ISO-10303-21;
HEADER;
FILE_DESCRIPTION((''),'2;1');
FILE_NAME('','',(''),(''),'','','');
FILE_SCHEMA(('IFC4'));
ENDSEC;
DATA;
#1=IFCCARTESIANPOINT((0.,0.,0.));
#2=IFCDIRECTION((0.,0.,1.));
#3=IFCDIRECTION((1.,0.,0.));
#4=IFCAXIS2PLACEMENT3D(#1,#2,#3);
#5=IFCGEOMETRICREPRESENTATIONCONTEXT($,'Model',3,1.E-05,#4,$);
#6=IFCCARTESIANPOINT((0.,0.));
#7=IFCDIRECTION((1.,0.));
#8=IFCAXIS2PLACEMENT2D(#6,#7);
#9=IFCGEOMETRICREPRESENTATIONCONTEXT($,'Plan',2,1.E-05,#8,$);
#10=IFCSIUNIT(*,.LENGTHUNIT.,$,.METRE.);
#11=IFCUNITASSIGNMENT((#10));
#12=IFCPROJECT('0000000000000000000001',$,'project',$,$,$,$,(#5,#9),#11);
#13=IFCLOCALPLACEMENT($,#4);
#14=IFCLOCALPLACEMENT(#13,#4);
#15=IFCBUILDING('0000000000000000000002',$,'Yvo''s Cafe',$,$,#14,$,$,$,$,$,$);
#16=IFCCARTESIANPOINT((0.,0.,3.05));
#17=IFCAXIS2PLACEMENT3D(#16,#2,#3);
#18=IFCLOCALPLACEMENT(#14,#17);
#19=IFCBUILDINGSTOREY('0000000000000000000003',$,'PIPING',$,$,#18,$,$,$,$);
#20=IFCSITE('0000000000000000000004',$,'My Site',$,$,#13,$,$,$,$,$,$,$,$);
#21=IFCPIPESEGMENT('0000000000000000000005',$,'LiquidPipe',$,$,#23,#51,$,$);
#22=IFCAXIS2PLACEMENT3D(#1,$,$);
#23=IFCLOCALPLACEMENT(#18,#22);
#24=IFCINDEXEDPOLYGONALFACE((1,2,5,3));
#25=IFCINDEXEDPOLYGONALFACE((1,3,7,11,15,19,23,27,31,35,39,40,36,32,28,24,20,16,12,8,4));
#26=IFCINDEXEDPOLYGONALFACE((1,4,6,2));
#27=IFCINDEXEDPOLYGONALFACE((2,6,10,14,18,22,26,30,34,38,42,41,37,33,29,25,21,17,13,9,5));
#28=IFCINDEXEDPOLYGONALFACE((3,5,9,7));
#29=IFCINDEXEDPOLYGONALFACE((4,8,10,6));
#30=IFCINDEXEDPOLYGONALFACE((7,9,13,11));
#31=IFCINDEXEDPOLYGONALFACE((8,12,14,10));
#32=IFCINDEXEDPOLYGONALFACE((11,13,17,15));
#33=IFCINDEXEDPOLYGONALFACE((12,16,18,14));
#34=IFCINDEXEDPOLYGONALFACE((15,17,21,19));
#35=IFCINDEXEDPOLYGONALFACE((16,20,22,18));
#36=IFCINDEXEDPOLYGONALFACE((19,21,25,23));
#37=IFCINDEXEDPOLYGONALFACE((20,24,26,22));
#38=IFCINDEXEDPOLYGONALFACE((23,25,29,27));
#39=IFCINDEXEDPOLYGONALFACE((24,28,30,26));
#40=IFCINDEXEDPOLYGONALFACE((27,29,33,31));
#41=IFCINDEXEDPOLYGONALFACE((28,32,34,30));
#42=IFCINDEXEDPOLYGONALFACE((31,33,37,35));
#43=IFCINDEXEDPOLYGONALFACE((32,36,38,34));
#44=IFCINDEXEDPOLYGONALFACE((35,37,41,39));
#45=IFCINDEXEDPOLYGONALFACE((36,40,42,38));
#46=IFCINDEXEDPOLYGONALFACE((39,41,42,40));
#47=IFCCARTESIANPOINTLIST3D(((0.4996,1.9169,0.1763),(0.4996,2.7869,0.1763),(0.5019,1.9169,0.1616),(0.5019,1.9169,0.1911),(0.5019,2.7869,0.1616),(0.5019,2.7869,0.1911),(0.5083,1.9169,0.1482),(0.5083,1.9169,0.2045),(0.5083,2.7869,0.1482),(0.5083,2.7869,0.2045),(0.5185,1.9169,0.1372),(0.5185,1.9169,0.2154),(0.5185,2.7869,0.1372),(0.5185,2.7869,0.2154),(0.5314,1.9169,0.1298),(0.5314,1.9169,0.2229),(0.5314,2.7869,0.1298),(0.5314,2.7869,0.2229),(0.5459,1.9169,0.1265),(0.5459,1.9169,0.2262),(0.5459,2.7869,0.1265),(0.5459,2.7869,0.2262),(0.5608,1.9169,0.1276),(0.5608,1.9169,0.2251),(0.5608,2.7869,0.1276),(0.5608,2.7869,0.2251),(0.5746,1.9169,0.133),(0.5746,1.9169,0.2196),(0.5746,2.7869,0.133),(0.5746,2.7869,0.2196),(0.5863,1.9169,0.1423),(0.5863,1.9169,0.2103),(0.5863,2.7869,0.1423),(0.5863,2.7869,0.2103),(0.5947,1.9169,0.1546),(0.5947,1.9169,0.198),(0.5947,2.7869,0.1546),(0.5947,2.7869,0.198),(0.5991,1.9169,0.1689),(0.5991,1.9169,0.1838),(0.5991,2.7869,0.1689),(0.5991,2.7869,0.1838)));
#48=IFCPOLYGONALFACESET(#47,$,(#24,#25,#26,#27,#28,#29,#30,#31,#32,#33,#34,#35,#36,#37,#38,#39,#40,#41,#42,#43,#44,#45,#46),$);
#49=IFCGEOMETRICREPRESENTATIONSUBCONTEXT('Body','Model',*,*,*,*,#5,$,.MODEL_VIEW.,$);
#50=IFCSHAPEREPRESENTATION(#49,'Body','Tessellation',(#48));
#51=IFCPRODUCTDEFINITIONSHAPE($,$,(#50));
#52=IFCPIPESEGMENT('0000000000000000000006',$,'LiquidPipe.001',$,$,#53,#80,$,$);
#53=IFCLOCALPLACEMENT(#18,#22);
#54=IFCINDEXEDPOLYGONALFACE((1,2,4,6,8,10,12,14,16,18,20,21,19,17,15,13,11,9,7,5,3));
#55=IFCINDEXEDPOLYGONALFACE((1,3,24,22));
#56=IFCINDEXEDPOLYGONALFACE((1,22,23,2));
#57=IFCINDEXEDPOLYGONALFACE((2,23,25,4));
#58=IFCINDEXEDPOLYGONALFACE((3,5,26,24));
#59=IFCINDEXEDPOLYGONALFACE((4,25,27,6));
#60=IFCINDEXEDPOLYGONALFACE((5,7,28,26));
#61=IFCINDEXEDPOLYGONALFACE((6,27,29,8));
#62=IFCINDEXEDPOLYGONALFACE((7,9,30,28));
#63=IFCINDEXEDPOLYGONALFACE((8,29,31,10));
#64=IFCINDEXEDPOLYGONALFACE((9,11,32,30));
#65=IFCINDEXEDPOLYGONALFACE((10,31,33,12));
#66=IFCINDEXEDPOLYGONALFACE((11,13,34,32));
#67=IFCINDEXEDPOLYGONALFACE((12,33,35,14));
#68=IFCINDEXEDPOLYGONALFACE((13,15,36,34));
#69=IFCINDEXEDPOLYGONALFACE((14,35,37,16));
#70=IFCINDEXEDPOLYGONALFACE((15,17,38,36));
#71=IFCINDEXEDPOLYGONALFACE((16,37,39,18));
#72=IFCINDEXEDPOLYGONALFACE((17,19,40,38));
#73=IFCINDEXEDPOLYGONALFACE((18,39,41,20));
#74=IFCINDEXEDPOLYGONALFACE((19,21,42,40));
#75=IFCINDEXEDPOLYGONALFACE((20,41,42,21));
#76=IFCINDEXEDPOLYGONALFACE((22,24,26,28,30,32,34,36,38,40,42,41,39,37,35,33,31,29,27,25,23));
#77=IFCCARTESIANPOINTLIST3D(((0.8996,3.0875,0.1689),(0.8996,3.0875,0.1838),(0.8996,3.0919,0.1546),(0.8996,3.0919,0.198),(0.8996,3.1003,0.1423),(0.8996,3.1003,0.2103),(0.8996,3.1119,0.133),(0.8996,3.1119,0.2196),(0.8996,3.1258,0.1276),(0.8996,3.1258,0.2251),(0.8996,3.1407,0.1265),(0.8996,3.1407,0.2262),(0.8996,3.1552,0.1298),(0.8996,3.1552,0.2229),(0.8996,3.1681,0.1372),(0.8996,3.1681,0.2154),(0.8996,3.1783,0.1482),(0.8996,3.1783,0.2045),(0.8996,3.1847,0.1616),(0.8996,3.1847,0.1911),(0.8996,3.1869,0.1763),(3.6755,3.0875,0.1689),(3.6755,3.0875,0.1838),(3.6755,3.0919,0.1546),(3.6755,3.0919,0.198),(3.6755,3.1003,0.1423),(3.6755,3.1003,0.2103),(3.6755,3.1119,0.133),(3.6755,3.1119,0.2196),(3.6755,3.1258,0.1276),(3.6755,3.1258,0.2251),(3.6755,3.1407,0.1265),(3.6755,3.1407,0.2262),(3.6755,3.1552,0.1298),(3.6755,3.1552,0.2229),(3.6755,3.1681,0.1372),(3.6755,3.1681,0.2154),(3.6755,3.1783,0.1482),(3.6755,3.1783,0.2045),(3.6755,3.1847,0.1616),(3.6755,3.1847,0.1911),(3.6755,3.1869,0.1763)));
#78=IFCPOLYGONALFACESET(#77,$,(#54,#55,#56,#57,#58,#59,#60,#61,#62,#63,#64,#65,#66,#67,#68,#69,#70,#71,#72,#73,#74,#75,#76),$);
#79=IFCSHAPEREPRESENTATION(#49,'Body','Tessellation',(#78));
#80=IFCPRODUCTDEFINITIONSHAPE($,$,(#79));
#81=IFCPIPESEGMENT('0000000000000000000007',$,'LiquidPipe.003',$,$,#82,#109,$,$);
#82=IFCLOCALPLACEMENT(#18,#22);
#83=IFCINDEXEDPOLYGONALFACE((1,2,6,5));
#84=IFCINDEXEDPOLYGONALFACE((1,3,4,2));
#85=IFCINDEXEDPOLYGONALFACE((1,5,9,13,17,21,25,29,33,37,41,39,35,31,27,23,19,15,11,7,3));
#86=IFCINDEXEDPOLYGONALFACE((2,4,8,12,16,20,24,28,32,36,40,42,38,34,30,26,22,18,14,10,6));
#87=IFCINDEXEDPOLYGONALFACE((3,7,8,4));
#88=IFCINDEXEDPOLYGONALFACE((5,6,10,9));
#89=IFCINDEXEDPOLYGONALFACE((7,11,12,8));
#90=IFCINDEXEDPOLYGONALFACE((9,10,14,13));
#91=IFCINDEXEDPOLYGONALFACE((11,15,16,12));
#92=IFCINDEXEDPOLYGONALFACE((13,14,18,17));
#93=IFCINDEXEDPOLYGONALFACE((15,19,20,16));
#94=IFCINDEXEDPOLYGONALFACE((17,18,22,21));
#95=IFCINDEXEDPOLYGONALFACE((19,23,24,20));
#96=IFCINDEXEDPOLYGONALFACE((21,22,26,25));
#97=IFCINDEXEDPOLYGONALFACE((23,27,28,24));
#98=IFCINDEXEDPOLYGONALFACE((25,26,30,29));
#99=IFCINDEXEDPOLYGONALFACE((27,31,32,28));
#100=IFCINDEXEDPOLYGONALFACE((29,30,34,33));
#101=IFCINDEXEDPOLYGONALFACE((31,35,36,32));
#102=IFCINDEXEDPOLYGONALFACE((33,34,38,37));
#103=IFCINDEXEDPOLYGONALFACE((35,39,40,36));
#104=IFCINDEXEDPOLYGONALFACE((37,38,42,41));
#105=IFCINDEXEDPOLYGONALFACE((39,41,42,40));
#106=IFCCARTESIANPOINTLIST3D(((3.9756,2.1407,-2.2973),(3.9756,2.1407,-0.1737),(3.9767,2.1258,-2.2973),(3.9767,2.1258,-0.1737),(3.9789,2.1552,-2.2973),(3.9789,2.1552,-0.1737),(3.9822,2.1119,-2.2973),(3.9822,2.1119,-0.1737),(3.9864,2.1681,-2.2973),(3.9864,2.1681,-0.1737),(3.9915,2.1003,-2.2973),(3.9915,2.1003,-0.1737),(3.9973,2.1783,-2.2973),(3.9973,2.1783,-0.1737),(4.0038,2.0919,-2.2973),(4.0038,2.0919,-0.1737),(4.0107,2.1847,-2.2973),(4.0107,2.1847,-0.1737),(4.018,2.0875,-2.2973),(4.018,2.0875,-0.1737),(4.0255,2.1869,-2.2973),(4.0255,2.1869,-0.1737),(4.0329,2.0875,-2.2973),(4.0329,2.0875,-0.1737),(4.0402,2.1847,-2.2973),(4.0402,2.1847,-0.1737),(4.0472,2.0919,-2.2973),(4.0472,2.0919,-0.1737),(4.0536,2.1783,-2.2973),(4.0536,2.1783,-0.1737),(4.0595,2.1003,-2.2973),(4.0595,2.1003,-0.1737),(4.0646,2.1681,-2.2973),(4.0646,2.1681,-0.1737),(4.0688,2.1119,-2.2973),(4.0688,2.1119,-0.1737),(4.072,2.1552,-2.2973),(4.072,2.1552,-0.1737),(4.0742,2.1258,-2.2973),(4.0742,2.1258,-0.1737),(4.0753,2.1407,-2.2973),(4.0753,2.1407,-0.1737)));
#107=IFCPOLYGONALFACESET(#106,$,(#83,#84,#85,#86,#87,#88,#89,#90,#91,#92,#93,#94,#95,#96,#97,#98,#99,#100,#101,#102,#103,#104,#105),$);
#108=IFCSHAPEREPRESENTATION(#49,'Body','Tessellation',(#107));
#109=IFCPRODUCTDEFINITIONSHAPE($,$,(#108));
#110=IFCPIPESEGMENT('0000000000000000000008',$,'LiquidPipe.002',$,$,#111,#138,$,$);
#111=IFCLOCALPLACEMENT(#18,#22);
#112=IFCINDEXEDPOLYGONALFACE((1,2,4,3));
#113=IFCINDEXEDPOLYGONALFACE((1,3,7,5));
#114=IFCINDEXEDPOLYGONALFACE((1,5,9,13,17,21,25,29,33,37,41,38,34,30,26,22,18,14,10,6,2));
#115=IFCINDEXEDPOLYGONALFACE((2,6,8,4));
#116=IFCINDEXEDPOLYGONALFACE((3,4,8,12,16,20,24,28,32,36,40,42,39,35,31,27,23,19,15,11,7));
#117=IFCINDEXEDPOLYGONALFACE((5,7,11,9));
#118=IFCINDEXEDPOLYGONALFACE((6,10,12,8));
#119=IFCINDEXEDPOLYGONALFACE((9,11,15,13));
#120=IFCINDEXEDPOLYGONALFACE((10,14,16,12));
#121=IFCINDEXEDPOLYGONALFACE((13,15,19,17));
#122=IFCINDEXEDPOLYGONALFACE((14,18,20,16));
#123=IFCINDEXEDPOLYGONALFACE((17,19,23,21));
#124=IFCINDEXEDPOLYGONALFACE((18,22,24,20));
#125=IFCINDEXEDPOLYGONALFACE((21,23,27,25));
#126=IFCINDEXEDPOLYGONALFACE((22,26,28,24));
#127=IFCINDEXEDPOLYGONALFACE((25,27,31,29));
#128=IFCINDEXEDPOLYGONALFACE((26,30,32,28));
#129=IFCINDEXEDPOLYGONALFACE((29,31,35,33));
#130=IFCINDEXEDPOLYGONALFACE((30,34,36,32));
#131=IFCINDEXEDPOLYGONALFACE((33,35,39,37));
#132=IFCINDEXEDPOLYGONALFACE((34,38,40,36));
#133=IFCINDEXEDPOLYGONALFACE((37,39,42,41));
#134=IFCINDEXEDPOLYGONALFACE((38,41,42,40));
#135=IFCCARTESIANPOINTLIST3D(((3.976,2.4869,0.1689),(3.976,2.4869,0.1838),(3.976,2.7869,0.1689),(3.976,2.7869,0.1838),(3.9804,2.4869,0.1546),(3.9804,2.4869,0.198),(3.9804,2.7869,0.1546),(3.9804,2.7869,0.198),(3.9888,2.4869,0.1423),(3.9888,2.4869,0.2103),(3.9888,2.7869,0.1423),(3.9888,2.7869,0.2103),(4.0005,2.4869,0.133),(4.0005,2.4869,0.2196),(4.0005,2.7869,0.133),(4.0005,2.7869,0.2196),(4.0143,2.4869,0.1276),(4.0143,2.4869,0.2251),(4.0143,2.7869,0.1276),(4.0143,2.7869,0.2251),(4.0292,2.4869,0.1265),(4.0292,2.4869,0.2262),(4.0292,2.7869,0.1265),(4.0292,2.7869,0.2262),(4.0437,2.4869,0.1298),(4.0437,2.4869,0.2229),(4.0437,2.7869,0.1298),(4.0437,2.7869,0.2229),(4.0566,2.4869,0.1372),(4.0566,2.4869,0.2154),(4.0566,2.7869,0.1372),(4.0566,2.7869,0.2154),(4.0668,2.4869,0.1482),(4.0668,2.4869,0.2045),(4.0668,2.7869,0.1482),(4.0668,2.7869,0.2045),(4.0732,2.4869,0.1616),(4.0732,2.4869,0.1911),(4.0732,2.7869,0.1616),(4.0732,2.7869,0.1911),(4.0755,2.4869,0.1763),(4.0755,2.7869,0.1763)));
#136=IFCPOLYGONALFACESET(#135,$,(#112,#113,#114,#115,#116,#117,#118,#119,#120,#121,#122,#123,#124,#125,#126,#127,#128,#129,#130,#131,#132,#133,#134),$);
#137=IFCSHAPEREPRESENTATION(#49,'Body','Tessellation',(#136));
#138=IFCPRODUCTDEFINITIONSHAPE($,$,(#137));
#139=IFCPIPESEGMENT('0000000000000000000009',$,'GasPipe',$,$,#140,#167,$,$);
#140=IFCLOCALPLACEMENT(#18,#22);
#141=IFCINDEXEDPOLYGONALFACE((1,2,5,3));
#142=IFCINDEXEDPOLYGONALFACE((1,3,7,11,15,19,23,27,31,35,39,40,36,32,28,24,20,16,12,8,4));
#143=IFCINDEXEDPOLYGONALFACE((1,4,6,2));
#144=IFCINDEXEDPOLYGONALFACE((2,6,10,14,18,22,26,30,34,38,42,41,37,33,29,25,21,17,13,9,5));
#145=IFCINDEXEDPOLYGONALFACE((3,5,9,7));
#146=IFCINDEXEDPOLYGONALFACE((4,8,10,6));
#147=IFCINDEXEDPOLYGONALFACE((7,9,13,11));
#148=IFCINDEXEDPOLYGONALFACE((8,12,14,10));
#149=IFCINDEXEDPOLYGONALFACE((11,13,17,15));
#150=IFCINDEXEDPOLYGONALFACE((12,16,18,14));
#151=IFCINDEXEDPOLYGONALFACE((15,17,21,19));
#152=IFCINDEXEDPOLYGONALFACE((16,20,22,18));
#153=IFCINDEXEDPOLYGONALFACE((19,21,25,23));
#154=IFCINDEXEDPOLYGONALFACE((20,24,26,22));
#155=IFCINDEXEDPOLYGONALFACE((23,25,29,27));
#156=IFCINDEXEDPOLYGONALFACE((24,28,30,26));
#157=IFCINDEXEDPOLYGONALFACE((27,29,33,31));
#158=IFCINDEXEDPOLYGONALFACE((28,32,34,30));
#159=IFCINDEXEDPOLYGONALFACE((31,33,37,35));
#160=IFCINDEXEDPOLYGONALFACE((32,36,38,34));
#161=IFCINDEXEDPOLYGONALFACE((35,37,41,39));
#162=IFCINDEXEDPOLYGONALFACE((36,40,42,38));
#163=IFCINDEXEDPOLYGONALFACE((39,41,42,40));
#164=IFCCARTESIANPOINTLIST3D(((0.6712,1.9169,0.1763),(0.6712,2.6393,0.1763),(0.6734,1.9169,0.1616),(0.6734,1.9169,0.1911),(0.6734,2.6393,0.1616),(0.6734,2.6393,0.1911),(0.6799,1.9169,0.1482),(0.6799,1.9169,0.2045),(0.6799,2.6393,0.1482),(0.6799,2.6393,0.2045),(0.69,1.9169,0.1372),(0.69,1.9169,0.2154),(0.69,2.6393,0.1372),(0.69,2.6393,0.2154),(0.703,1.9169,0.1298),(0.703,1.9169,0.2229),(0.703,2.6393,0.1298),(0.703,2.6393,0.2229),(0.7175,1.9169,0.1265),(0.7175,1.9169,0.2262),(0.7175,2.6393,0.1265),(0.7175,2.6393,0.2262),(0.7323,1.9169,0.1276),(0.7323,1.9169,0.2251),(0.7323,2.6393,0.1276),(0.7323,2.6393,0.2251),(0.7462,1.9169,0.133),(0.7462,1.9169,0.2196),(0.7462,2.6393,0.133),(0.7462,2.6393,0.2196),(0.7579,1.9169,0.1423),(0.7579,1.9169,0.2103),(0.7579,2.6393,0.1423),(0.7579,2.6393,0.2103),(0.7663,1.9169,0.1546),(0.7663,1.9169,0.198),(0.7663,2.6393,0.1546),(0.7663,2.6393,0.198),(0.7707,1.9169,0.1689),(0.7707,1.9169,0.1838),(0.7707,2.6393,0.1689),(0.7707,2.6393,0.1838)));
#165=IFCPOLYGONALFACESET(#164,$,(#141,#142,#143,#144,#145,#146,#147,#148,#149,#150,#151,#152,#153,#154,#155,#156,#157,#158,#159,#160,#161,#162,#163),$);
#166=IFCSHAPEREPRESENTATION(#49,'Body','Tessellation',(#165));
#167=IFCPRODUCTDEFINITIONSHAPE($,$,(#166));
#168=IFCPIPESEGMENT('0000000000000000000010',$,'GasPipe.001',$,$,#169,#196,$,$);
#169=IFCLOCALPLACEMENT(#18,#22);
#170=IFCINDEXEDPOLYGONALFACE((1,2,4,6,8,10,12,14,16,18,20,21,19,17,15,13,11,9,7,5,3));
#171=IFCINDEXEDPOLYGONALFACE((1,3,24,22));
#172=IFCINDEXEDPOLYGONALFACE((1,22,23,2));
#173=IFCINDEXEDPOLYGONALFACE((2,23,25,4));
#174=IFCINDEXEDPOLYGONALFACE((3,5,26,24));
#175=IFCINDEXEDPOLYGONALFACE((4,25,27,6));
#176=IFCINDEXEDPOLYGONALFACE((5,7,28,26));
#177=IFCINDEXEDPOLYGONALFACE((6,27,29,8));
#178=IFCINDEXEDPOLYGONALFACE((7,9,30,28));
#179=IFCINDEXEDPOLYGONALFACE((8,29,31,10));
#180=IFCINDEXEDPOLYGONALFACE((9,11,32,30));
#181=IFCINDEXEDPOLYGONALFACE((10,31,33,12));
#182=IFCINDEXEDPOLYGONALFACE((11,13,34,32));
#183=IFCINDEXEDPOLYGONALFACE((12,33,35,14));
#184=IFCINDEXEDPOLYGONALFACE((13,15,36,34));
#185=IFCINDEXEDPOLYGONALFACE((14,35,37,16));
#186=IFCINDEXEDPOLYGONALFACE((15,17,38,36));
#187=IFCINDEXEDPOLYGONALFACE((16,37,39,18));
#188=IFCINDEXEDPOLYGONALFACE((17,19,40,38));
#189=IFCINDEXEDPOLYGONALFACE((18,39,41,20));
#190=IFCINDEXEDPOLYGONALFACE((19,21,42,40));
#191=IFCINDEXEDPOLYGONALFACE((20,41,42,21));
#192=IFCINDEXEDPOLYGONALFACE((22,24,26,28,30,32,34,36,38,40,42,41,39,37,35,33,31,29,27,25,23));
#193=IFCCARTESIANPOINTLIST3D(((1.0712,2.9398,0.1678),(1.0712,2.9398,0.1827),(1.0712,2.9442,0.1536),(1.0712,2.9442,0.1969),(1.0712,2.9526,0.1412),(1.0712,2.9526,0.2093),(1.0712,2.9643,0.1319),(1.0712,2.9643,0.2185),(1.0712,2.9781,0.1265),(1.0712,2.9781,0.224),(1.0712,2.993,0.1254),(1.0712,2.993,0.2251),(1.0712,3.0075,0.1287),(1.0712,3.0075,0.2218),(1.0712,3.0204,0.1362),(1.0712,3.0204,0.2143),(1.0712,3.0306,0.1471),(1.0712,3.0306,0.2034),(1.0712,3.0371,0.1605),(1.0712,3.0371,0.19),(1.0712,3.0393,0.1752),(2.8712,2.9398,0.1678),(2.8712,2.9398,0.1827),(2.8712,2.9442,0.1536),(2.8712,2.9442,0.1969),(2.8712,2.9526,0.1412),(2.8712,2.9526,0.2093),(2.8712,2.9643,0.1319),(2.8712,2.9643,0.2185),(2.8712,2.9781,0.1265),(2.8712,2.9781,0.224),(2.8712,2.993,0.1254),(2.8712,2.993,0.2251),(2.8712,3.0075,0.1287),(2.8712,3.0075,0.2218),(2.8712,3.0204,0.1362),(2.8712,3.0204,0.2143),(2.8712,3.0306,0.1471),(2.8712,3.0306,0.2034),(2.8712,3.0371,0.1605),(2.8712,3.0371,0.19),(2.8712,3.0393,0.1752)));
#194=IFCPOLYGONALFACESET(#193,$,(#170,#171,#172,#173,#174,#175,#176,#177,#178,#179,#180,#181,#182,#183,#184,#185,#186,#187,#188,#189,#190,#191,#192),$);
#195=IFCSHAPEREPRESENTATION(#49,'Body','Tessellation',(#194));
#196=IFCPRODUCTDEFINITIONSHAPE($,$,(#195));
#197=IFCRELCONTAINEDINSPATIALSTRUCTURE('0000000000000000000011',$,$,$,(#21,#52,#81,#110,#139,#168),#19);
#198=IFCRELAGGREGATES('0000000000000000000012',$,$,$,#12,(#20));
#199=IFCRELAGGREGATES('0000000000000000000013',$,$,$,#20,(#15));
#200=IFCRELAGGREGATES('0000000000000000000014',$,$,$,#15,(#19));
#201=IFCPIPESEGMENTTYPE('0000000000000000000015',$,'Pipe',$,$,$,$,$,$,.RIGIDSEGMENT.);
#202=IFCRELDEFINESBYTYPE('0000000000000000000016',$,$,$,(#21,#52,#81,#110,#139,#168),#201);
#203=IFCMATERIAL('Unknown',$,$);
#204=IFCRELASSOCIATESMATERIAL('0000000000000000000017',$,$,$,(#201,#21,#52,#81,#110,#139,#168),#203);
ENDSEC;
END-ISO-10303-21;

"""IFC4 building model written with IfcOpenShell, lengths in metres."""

from ifc_helpers import new_model, si_unit, frame, origin_with_axes, origin_2d_with_axis, place, context, subcontext, project, spatial, circle, extrude, material, material_profile, profile_set, profile_usage, type_object, element, save


model = new_model("IFC4")

# Units and contexts
model_context = context("Model", 3, precision=1e-05, world=origin_with_axes())
plan_context = context("Plan", 2, precision=1e-05, world=origin_2d_with_axis())
body_context = subcontext(model_context, "Body", "Model", "MODEL_VIEW")
ifc_project = project(units=[si_unit("LENGTHUNIT", "METRE")], contexts=[model_context, plan_context])

# Site, building, storey
site_placement = place(None, origin_with_axes())
site = spatial("IfcSite", under=ifc_project, at=site_placement, Name="My Site")
building_placement = place(site_placement, origin_with_axes())
building = spatial("IfcBuilding", under=site, at=building_placement, Name="Yvo's Cafe")
storey_placement = place(building_placement, frame((0.0, 0.0, 3.05), z_axis=(0.0, 0.0, 1.0), x_axis=(1.0, 0.0, 0.0)))
storey = spatial("IfcBuildingStorey", under=building, at=storey_placement, Name="PIPING")

# Pipe segments
ifc_material = material(Name="Unknown")
ifc_material_profile = material_profile(ifc_material, circle(Radius=0.05))
ifc_profile_set = profile_set([ifc_material_profile])
ifc_profile_usage_1 = profile_usage(ifc_profile_set, cardinal=5)
pipe_segment_type = type_object("IfcPipeSegmentType", Name="Pipe", PredefinedType="RIGIDSEGMENT", material=ifc_profile_set)
pipe_segment_1_placement = place(storey_placement, frame((0.5496, 1.9169, 0.1763), z_axis=(0.0, 1.0, 0.0), x_axis=(-1.0, 0.0, 0.0)))
element("IfcPipeSegment", 1, at=pipe_segment_1_placement, inside=storey, type_object=pipe_segment_type, material=ifc_profile_usage_1, Name="LiquidPipe", context=body_context, shape_type="SweptSolid", body=[
    extrude(circle(Radius=0.05), origin_with_axes(), (0.0, 0.0, 1.0), 0.8701),
])
ifc_profile_usage_2 = profile_usage(ifc_profile_set, cardinal=5)
pipe_segment_2_placement = place(storey_placement, frame((0.8996, 3.1369, 0.1763), z_axis=(1.0, 0.0, 0.0), x_axis=(0.0, 1.0, 0.0)))
element("IfcPipeSegment", 2, at=pipe_segment_2_placement, inside=storey, type_object=pipe_segment_type, material=ifc_profile_usage_2, Name="LiquidPipe.001", context=body_context, shape_type="SweptSolid", body=[
    extrude(circle(Radius=0.05), origin_with_axes(), (0.0, 0.0, 1.0), 2.7758),
])
ifc_profile_usage_3 = profile_usage(ifc_profile_set, cardinal=5)
pipe_segment_3_placement = place(storey_placement, frame((4.0255, 2.1369, -2.2973), z_axis=(0.0, 0.0, 1.0), x_axis=(0.0, 1.0, 0.0)))
element("IfcPipeSegment", 3, at=pipe_segment_3_placement, inside=storey, type_object=pipe_segment_type, material=ifc_profile_usage_3, Name="LiquidPipe.003", context=body_context, shape_type="SweptSolid", body=[
    extrude(circle(Radius=0.05), origin_with_axes(), (0.0, 0.0, 1.0), 2.1236),
])
ifc_profile_usage_4 = profile_usage(ifc_profile_set, cardinal=5)
pipe_segment_4_placement = place(storey_placement, frame((4.0255, 2.7869, 0.1763), z_axis=(0.0, -1.0, 0.0), x_axis=(1.0, 0.0, 0.0)))
element("IfcPipeSegment", 4, at=pipe_segment_4_placement, inside=storey, type_object=pipe_segment_type, material=ifc_profile_usage_4, Name="LiquidPipe.002", context=body_context, shape_type="SweptSolid", body=[
    extrude(circle(Radius=0.05), origin_with_axes(), (0.0, 0.0, 1.0), 0.3),
])
ifc_profile_usage_5 = profile_usage(ifc_profile_set, cardinal=5)
pipe_segment_5_placement = place(storey_placement, frame((0.7212, 1.9169, 0.1763), z_axis=(0.0, 1.0, 0.0), x_axis=(-1.0, 0.0, 0.0)))
element("IfcPipeSegment", 5, at=pipe_segment_5_placement, inside=storey, type_object=pipe_segment_type, material=ifc_profile_usage_5, Name="GasPipe", context=body_context, shape_type="SweptSolid", body=[
    extrude(circle(Radius=0.05), origin_with_axes(), (0.0, 0.0, 1.0), 0.7224),
])
ifc_profile_usage_6 = profile_usage(ifc_profile_set, cardinal=5)
pipe_segment_6_placement = place(storey_placement, frame((1.0712, 2.9893, 0.1752), z_axis=(1.0, 0.0, 0.0), x_axis=(0.0, 1.0, 0.0)))
element("IfcPipeSegment", 6, at=pipe_segment_6_placement, inside=storey, type_object=pipe_segment_type, material=ifc_profile_usage_6, Name="GasPipe.001", context=body_context, shape_type="SweptSolid", body=[
    extrude(circle(Radius=0.05), origin_with_axes(), (0.0, 0.0, 1.0), 1.8),
])

save(model, "model.ifc")
